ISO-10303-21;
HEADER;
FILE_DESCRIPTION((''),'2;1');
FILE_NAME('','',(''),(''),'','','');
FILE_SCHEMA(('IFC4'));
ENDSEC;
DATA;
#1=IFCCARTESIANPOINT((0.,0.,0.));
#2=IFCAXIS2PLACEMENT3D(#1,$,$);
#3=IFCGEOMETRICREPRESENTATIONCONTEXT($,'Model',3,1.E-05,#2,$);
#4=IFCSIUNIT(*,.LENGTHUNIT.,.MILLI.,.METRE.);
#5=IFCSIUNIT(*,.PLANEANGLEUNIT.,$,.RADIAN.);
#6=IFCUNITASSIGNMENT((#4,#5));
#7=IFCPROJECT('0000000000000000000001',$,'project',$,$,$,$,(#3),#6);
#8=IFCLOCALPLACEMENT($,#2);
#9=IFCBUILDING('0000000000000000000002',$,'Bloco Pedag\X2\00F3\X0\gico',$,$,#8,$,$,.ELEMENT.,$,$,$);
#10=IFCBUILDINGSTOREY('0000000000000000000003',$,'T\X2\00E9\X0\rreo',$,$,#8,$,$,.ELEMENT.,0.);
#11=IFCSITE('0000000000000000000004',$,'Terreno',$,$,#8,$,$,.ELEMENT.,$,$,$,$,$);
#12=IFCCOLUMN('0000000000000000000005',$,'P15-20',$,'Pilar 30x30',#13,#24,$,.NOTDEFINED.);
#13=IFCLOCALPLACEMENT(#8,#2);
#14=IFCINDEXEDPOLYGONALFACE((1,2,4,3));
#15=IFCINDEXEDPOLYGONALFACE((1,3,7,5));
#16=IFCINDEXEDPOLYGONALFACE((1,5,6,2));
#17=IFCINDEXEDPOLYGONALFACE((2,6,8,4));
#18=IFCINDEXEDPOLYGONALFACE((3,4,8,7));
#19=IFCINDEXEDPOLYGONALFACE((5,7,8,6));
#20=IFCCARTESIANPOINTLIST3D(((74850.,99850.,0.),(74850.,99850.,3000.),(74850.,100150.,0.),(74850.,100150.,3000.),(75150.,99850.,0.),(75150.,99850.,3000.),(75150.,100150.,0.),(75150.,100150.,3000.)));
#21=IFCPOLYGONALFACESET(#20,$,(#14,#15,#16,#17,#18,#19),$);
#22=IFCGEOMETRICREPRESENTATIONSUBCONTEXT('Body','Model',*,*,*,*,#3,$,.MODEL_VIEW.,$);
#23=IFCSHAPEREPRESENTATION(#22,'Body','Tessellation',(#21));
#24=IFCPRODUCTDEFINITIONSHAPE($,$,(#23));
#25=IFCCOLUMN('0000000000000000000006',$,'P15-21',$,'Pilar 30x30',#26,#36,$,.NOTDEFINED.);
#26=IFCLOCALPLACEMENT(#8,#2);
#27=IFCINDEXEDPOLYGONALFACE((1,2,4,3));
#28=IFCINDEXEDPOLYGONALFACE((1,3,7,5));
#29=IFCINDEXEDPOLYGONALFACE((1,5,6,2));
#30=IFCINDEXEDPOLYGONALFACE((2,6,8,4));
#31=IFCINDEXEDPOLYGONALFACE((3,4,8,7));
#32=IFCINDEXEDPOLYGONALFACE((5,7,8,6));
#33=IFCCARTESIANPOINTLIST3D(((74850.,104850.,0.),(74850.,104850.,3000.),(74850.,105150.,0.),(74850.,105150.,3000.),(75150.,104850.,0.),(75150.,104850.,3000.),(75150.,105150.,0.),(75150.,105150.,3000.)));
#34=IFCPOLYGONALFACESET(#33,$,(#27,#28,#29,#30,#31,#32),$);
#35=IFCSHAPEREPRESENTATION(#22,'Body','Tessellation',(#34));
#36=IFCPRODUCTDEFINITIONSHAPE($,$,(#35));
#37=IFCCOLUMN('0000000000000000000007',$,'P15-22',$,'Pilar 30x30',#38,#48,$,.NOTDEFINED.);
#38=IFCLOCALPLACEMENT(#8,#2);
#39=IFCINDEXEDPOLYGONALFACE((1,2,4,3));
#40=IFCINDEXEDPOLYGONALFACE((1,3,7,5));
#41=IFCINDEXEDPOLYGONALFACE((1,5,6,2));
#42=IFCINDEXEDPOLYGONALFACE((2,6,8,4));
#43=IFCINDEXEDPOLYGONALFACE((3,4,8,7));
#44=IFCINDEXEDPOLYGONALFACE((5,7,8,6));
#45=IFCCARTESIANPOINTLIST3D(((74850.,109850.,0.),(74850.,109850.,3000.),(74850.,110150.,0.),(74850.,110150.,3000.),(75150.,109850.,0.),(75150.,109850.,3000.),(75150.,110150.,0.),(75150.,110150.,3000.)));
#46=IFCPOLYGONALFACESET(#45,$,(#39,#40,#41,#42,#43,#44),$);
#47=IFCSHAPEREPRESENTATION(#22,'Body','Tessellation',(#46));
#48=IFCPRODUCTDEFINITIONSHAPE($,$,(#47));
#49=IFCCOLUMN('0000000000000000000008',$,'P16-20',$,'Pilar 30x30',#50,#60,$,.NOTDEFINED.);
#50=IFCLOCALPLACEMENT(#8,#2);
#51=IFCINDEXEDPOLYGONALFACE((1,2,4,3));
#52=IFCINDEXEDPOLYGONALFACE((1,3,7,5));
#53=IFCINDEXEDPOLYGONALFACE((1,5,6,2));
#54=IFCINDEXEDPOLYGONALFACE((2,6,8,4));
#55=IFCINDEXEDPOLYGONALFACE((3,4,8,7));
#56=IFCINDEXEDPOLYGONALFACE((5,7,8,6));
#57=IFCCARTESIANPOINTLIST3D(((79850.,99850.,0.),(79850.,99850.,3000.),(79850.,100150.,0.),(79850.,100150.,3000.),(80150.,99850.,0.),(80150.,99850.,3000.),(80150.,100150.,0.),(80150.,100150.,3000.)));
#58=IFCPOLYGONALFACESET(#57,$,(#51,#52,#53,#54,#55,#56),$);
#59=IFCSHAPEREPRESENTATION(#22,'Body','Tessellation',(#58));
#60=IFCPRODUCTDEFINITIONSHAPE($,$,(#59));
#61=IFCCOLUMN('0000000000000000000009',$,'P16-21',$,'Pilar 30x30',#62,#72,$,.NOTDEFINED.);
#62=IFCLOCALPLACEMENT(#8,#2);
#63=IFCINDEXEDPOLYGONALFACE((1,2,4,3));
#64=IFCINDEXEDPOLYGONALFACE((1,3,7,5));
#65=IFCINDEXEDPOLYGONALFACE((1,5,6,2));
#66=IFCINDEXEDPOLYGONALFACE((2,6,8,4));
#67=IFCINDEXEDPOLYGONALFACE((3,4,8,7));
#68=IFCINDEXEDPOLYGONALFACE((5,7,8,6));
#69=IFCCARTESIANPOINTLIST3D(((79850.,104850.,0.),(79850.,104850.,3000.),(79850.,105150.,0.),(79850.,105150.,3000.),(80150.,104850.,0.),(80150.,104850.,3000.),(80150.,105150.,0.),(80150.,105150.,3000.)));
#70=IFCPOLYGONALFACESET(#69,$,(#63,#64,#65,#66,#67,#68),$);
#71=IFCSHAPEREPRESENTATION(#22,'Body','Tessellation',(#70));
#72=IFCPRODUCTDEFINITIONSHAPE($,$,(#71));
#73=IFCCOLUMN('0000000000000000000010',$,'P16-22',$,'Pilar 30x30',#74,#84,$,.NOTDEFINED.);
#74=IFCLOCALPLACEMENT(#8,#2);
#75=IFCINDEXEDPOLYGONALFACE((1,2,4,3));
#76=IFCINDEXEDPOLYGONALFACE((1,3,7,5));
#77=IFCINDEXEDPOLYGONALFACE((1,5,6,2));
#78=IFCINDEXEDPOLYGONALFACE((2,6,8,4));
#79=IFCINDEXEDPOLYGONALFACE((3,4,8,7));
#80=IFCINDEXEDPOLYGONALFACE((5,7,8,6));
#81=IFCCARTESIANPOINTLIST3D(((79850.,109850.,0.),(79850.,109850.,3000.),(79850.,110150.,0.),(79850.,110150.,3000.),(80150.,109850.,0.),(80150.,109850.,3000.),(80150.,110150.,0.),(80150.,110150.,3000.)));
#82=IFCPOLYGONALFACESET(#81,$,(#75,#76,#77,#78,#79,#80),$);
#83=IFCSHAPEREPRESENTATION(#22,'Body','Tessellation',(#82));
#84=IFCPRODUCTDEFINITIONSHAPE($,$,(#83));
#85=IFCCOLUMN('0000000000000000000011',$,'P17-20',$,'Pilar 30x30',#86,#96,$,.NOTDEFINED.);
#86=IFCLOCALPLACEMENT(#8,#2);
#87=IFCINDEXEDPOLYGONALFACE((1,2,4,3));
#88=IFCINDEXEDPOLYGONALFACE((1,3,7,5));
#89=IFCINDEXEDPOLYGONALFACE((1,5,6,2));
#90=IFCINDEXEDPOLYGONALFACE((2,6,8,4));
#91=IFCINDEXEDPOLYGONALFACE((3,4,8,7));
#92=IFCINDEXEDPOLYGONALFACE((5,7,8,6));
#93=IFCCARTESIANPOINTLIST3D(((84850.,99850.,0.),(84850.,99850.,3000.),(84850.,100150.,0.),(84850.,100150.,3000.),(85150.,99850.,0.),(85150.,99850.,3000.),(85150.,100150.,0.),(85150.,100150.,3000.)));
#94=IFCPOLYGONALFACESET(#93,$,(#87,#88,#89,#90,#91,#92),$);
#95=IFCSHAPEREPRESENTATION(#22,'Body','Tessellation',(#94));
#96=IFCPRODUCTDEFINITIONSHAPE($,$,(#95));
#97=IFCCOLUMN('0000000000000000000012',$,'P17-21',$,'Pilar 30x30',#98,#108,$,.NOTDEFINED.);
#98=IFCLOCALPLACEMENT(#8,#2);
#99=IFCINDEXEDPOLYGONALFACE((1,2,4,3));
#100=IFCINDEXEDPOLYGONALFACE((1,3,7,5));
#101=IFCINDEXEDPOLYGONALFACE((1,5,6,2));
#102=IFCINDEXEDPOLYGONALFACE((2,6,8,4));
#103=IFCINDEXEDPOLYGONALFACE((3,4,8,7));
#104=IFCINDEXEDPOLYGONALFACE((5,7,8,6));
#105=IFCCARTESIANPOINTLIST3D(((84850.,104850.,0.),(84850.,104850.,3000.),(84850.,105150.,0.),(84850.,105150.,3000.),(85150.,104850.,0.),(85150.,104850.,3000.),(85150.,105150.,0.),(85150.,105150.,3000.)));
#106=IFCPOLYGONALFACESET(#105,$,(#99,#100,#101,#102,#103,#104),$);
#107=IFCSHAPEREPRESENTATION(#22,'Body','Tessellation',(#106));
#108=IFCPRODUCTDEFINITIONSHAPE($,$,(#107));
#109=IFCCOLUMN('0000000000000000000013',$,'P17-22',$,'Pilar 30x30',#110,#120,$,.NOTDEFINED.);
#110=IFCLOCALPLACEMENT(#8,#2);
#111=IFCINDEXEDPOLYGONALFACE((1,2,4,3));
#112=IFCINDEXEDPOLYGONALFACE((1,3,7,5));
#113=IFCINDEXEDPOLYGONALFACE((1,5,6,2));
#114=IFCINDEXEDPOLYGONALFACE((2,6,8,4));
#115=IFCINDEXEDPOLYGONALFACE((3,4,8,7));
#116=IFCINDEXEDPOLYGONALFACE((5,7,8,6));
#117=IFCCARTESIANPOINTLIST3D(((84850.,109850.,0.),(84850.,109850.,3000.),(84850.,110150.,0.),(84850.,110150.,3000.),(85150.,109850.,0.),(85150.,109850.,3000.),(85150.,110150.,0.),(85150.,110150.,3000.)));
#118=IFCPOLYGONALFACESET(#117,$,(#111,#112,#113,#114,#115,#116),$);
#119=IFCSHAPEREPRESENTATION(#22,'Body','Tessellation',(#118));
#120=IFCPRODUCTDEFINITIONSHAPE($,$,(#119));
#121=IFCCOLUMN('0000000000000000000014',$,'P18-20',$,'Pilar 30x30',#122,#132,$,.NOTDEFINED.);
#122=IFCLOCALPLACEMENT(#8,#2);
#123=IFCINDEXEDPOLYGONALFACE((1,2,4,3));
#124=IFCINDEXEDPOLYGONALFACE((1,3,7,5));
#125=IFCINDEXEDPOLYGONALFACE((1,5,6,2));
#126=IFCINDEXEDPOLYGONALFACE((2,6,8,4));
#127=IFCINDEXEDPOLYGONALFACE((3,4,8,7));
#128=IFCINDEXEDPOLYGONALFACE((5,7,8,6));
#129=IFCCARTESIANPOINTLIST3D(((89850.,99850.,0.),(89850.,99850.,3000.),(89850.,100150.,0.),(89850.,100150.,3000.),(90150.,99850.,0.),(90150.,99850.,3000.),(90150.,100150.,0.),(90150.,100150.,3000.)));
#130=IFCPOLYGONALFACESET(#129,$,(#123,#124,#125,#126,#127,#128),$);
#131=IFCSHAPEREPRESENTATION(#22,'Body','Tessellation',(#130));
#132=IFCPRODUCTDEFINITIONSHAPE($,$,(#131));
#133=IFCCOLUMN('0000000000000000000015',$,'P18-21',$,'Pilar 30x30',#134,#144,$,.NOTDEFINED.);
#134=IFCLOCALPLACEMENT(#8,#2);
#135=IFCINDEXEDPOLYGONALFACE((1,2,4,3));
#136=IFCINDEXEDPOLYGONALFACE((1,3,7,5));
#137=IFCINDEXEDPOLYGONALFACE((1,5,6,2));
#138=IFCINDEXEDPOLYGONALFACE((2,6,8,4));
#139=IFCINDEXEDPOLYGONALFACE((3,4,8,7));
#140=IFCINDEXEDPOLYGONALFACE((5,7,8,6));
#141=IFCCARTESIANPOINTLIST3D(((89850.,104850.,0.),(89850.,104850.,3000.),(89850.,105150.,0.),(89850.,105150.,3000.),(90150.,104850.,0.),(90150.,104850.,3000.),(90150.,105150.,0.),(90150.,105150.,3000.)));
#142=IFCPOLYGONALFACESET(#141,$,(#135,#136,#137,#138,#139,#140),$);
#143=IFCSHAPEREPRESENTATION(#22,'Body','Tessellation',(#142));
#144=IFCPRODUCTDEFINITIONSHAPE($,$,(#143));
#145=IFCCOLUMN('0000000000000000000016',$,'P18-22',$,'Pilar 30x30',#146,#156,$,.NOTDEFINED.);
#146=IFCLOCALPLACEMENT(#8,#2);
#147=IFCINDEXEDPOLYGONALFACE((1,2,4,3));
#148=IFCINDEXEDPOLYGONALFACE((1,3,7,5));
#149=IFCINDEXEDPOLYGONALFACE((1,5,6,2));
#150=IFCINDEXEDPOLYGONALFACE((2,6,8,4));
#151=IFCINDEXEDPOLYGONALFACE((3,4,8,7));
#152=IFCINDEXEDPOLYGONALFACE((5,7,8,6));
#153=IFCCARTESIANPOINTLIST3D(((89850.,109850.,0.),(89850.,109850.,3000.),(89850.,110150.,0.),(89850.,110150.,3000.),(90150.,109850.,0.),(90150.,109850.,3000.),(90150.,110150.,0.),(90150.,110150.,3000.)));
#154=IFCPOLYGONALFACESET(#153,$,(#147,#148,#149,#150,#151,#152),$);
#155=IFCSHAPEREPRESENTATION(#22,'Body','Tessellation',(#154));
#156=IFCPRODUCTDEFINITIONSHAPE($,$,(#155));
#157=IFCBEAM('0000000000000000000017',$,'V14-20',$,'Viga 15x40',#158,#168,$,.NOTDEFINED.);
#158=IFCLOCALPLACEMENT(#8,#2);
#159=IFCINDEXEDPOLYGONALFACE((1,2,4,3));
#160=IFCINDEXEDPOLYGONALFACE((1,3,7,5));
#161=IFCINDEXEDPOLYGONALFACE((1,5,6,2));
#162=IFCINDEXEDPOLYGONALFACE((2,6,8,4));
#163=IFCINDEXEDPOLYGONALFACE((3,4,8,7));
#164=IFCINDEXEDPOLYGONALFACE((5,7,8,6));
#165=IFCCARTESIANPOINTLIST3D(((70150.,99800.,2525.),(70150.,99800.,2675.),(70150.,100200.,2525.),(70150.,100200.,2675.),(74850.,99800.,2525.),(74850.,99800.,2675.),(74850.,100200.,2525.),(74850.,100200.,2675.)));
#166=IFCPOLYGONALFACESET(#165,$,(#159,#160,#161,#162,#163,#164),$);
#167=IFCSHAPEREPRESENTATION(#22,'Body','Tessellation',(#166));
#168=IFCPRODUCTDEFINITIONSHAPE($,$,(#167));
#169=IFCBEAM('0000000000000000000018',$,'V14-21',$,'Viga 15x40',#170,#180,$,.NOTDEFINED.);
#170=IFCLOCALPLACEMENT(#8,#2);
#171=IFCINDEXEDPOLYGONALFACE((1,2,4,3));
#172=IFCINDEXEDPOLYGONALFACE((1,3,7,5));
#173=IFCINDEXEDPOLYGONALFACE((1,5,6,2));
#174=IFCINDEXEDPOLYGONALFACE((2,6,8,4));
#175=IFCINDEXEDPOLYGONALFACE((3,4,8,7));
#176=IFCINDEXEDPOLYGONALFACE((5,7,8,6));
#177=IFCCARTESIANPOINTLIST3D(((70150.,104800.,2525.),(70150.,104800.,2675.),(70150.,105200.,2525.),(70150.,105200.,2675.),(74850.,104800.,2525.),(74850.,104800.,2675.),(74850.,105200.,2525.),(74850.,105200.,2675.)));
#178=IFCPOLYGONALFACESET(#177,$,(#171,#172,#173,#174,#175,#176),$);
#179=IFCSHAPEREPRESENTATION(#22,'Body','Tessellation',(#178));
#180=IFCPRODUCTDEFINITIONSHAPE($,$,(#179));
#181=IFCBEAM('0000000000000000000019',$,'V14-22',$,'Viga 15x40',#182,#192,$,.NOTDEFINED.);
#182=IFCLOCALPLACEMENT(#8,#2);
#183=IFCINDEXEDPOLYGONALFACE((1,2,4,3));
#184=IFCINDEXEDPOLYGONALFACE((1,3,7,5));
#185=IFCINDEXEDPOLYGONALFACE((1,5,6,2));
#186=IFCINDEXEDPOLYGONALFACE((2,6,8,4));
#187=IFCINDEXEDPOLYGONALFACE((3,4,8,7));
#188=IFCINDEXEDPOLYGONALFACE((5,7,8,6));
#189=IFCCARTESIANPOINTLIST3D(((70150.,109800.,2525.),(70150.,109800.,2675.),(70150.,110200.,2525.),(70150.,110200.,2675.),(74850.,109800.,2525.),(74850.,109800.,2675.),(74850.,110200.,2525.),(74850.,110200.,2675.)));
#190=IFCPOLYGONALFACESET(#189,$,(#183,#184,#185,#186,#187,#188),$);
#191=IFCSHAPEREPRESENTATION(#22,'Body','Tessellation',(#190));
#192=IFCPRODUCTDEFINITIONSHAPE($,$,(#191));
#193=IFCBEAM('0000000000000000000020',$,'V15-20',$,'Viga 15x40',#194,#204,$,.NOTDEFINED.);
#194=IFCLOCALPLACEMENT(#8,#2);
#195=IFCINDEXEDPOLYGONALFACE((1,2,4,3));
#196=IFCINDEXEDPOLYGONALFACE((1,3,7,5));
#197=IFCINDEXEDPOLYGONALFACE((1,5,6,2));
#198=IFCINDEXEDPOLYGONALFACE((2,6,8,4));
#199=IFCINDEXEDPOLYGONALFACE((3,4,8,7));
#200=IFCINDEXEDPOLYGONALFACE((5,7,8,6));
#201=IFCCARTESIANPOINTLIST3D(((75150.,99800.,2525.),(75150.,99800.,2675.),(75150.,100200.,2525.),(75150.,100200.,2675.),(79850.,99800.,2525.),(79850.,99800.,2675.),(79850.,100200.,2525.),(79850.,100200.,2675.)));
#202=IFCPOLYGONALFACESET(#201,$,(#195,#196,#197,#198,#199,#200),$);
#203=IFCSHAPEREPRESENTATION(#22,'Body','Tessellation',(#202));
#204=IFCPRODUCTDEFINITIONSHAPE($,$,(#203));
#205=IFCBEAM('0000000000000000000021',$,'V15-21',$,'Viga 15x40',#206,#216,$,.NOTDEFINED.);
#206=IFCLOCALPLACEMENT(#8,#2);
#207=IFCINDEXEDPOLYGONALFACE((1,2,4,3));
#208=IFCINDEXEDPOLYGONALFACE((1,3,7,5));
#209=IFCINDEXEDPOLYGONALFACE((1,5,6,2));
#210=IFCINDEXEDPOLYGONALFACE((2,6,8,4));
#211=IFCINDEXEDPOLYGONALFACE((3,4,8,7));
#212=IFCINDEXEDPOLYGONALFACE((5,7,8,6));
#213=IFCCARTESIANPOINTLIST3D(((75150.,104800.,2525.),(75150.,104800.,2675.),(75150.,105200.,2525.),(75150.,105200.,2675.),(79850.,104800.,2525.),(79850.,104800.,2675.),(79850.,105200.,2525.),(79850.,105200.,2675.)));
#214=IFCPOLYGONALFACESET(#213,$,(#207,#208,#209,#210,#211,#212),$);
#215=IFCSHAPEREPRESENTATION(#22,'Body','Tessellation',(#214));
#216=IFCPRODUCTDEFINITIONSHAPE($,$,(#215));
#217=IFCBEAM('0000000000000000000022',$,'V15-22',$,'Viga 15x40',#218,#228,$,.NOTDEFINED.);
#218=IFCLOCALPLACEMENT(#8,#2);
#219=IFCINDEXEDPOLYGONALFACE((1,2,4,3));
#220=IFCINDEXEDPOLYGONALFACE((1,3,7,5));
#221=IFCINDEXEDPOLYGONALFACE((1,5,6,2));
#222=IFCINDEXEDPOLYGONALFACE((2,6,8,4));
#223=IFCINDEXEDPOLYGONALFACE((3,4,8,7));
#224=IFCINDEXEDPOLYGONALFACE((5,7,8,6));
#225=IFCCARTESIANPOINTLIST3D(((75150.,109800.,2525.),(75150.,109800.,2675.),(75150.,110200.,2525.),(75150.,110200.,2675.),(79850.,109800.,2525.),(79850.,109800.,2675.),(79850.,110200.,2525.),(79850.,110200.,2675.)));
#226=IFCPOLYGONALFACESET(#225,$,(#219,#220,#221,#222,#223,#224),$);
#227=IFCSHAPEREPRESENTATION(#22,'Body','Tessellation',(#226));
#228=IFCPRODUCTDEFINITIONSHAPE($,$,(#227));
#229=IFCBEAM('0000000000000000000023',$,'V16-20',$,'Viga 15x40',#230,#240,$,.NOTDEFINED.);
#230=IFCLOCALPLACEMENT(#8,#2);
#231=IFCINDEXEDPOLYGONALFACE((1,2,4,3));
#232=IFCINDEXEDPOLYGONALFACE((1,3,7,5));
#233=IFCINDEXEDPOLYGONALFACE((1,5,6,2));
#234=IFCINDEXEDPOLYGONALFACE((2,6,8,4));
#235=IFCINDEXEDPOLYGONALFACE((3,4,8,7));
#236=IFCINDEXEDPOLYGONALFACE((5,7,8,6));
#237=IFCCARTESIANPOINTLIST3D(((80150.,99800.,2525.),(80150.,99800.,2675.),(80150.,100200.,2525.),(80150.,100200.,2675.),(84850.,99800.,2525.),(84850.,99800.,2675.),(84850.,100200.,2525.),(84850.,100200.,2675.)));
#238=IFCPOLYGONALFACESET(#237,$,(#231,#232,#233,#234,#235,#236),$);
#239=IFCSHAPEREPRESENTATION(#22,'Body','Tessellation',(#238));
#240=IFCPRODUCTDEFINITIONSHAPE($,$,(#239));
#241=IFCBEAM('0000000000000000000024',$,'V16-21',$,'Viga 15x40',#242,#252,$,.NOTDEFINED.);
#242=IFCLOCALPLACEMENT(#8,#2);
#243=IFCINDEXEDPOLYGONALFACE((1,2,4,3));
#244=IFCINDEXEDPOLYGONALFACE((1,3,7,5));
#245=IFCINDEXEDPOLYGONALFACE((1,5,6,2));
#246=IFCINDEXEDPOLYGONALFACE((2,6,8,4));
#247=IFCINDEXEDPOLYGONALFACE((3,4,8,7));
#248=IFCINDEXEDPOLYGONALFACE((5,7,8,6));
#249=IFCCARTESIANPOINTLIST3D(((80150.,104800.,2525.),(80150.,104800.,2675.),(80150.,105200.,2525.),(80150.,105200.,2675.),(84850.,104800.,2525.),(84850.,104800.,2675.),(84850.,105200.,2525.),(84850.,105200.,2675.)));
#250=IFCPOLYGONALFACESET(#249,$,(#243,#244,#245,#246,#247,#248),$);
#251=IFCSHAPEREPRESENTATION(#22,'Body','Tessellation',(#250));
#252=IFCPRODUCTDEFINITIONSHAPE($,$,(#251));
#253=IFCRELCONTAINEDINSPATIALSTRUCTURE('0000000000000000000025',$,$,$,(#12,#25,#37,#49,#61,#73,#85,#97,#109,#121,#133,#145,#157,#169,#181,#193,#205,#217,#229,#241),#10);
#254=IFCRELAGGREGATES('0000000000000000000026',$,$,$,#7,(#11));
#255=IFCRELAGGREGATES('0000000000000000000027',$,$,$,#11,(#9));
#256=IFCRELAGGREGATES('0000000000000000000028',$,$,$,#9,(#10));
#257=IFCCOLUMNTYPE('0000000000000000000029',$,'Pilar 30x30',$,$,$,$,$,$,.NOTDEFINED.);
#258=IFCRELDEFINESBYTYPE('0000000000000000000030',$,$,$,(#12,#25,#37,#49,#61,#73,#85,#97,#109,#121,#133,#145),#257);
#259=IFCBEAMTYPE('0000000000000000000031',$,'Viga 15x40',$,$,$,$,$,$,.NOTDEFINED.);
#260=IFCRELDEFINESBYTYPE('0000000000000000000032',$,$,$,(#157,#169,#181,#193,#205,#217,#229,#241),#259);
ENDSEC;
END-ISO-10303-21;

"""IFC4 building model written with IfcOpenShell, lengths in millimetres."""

from ifc_helpers import new_model, si_unit, frame, origin, origin_2d, place, context, subcontext, project, spatial, rectangle, extrude, type_object, element, save


model = new_model("IFC4")

# Units and contexts
model_context = context("Model", 3, precision=1e-05, world=origin())
body_context = subcontext(model_context, "Body", "Model", "MODEL_VIEW")
ifc_project = project(units=[si_unit("LENGTHUNIT", "METRE", prefix="MILLI"), si_unit("PLANEANGLEUNIT", "RADIAN")], contexts=[model_context])

# Site, building, storey
placement = place(None, origin())
site = spatial("IfcSite", under=ifc_project, at=placement, Name="Terreno", CompositionType="ELEMENT")
building = spatial("IfcBuilding", under=site, at=placement, Name="Bloco Pedagógico", CompositionType="ELEMENT")
storey = spatial("IfcBuildingStorey", under=building, at=placement, Name="Térreo", CompositionType="ELEMENT", Elevation=0.0)

# Columns
column_type = type_object("IfcColumnType", Name="Pilar 30x30", PredefinedType="NOTDEFINED")
for number, where, z_axis, x_axis, name in (
    (1, (75000.0, 100000.0, 0.0), (0.0, 0.0, 1.0), (1.0, 0.0, 0.0), "P15-20"),
    (2, (75000.0, 105000.0, 0.0), (0.0, 0.0, 1.0), (1.0, 0.0, 0.0), "P15-21"),
    (3, (75000.0, 110000.0, 0.0), (0.0, 0.0, 1.0), (1.0, 0.0, 0.0), "P15-22"),
    (4, (80000.0, 100000.0, 0.0), (0.0, 0.0, 1.0), (1.0, 0.0, 0.0), "P16-20"),
    (5, (80000.0, 105000.0, 0.0), (0.0, 0.0, 1.0), (1.0, 0.0, 0.0), "P16-21"),
    (6, (80000.0, 110000.0, 0.0), (0.0, 0.0, 1.0), (1.0, 0.0, 0.0), "P16-22"),
    (7, (85000.0, 100000.0, 0.0), (0.0, 0.0, 1.0), (1.0, 0.0, 0.0), "P17-20"),
    (8, (85000.0, 105000.0, 0.0), (0.0, 0.0, 1.0), (1.0, 0.0, 0.0), "P17-21"),
    (9, (85000.0, 110000.0, 0.0), (0.0, 0.0, 1.0), (1.0, 0.0, 0.0), "P17-22"),
    (10, (90000.0, 100000.0, 0.0), (0.0, 0.0, 1.0), (1.0, 0.0, 0.0), "P18-20"),
    (11, (90000.0, 105000.0, 0.0), (0.0, 0.0, 1.0), (1.0, 0.0, 0.0), "P18-21"),
    (12, (90000.0, 110000.0, 0.0), (0.0, 0.0, 1.0), (1.0, 0.0, 0.0), "P18-22"),
):
    element("IfcColumn", number, at=place(None, frame(where, z_axis=z_axis, x_axis=x_axis)), inside=storey, type_object=column_type, Name=name, ObjectType="Pilar 30x30", PredefinedType="NOTDEFINED", context=body_context, shape_type="SweptSolid", body=[
        extrude(rectangle(XDim=300.0, YDim=300.0, at=origin_2d()), None, (0.0, 0.0, 1.0), 3000.0),
    ])

# Beams
beam_type = type_object("IfcBeamType", Name="Viga 15x40", PredefinedType="NOTDEFINED")
for number, where, z_axis, x_axis, name in (
    (13, (70150.0, 100000.0, 2600.0), (1.0, 0.0, 0.0), (0.0, 1.0, 0.0), "V14-20"),
    (14, (70150.0, 105000.0, 2600.0), (1.0, 0.0, 0.0), (0.0, 1.0, 0.0), "V14-21"),
    (15, (70150.0, 110000.0, 2600.0), (1.0, 0.0, 0.0), (0.0, 1.0, 0.0), "V14-22"),
    (16, (75150.0, 100000.0, 2600.0), (1.0, 0.0, 0.0), (0.0, 1.0, 0.0), "V15-20"),
    (17, (75150.0, 105000.0, 2600.0), (1.0, 0.0, 0.0), (0.0, 1.0, 0.0), "V15-21"),
    (18, (75150.0, 110000.0, 2600.0), (1.0, 0.0, 0.0), (0.0, 1.0, 0.0), "V15-22"),
    (19, (80150.0, 100000.0, 2600.0), (1.0, 0.0, 0.0), (0.0, 1.0, 0.0), "V16-20"),
    (20, (80150.0, 105000.0, 2600.0), (1.0, 0.0, 0.0), (0.0, 1.0, 0.0), "V16-21"),
):
    element("IfcBeam", number, at=place(None, frame(where, z_axis=z_axis, x_axis=x_axis)), inside=storey, type_object=beam_type, Name=name, ObjectType="Viga 15x40", PredefinedType="NOTDEFINED", context=body_context, shape_type="SweptSolid", body=[
        extrude(rectangle(XDim=400.0, YDim=150.0, at=origin_2d()), None, (0.0, 0.0, 1.0), 4700.0),
    ])

save(model, "model.ifc")
